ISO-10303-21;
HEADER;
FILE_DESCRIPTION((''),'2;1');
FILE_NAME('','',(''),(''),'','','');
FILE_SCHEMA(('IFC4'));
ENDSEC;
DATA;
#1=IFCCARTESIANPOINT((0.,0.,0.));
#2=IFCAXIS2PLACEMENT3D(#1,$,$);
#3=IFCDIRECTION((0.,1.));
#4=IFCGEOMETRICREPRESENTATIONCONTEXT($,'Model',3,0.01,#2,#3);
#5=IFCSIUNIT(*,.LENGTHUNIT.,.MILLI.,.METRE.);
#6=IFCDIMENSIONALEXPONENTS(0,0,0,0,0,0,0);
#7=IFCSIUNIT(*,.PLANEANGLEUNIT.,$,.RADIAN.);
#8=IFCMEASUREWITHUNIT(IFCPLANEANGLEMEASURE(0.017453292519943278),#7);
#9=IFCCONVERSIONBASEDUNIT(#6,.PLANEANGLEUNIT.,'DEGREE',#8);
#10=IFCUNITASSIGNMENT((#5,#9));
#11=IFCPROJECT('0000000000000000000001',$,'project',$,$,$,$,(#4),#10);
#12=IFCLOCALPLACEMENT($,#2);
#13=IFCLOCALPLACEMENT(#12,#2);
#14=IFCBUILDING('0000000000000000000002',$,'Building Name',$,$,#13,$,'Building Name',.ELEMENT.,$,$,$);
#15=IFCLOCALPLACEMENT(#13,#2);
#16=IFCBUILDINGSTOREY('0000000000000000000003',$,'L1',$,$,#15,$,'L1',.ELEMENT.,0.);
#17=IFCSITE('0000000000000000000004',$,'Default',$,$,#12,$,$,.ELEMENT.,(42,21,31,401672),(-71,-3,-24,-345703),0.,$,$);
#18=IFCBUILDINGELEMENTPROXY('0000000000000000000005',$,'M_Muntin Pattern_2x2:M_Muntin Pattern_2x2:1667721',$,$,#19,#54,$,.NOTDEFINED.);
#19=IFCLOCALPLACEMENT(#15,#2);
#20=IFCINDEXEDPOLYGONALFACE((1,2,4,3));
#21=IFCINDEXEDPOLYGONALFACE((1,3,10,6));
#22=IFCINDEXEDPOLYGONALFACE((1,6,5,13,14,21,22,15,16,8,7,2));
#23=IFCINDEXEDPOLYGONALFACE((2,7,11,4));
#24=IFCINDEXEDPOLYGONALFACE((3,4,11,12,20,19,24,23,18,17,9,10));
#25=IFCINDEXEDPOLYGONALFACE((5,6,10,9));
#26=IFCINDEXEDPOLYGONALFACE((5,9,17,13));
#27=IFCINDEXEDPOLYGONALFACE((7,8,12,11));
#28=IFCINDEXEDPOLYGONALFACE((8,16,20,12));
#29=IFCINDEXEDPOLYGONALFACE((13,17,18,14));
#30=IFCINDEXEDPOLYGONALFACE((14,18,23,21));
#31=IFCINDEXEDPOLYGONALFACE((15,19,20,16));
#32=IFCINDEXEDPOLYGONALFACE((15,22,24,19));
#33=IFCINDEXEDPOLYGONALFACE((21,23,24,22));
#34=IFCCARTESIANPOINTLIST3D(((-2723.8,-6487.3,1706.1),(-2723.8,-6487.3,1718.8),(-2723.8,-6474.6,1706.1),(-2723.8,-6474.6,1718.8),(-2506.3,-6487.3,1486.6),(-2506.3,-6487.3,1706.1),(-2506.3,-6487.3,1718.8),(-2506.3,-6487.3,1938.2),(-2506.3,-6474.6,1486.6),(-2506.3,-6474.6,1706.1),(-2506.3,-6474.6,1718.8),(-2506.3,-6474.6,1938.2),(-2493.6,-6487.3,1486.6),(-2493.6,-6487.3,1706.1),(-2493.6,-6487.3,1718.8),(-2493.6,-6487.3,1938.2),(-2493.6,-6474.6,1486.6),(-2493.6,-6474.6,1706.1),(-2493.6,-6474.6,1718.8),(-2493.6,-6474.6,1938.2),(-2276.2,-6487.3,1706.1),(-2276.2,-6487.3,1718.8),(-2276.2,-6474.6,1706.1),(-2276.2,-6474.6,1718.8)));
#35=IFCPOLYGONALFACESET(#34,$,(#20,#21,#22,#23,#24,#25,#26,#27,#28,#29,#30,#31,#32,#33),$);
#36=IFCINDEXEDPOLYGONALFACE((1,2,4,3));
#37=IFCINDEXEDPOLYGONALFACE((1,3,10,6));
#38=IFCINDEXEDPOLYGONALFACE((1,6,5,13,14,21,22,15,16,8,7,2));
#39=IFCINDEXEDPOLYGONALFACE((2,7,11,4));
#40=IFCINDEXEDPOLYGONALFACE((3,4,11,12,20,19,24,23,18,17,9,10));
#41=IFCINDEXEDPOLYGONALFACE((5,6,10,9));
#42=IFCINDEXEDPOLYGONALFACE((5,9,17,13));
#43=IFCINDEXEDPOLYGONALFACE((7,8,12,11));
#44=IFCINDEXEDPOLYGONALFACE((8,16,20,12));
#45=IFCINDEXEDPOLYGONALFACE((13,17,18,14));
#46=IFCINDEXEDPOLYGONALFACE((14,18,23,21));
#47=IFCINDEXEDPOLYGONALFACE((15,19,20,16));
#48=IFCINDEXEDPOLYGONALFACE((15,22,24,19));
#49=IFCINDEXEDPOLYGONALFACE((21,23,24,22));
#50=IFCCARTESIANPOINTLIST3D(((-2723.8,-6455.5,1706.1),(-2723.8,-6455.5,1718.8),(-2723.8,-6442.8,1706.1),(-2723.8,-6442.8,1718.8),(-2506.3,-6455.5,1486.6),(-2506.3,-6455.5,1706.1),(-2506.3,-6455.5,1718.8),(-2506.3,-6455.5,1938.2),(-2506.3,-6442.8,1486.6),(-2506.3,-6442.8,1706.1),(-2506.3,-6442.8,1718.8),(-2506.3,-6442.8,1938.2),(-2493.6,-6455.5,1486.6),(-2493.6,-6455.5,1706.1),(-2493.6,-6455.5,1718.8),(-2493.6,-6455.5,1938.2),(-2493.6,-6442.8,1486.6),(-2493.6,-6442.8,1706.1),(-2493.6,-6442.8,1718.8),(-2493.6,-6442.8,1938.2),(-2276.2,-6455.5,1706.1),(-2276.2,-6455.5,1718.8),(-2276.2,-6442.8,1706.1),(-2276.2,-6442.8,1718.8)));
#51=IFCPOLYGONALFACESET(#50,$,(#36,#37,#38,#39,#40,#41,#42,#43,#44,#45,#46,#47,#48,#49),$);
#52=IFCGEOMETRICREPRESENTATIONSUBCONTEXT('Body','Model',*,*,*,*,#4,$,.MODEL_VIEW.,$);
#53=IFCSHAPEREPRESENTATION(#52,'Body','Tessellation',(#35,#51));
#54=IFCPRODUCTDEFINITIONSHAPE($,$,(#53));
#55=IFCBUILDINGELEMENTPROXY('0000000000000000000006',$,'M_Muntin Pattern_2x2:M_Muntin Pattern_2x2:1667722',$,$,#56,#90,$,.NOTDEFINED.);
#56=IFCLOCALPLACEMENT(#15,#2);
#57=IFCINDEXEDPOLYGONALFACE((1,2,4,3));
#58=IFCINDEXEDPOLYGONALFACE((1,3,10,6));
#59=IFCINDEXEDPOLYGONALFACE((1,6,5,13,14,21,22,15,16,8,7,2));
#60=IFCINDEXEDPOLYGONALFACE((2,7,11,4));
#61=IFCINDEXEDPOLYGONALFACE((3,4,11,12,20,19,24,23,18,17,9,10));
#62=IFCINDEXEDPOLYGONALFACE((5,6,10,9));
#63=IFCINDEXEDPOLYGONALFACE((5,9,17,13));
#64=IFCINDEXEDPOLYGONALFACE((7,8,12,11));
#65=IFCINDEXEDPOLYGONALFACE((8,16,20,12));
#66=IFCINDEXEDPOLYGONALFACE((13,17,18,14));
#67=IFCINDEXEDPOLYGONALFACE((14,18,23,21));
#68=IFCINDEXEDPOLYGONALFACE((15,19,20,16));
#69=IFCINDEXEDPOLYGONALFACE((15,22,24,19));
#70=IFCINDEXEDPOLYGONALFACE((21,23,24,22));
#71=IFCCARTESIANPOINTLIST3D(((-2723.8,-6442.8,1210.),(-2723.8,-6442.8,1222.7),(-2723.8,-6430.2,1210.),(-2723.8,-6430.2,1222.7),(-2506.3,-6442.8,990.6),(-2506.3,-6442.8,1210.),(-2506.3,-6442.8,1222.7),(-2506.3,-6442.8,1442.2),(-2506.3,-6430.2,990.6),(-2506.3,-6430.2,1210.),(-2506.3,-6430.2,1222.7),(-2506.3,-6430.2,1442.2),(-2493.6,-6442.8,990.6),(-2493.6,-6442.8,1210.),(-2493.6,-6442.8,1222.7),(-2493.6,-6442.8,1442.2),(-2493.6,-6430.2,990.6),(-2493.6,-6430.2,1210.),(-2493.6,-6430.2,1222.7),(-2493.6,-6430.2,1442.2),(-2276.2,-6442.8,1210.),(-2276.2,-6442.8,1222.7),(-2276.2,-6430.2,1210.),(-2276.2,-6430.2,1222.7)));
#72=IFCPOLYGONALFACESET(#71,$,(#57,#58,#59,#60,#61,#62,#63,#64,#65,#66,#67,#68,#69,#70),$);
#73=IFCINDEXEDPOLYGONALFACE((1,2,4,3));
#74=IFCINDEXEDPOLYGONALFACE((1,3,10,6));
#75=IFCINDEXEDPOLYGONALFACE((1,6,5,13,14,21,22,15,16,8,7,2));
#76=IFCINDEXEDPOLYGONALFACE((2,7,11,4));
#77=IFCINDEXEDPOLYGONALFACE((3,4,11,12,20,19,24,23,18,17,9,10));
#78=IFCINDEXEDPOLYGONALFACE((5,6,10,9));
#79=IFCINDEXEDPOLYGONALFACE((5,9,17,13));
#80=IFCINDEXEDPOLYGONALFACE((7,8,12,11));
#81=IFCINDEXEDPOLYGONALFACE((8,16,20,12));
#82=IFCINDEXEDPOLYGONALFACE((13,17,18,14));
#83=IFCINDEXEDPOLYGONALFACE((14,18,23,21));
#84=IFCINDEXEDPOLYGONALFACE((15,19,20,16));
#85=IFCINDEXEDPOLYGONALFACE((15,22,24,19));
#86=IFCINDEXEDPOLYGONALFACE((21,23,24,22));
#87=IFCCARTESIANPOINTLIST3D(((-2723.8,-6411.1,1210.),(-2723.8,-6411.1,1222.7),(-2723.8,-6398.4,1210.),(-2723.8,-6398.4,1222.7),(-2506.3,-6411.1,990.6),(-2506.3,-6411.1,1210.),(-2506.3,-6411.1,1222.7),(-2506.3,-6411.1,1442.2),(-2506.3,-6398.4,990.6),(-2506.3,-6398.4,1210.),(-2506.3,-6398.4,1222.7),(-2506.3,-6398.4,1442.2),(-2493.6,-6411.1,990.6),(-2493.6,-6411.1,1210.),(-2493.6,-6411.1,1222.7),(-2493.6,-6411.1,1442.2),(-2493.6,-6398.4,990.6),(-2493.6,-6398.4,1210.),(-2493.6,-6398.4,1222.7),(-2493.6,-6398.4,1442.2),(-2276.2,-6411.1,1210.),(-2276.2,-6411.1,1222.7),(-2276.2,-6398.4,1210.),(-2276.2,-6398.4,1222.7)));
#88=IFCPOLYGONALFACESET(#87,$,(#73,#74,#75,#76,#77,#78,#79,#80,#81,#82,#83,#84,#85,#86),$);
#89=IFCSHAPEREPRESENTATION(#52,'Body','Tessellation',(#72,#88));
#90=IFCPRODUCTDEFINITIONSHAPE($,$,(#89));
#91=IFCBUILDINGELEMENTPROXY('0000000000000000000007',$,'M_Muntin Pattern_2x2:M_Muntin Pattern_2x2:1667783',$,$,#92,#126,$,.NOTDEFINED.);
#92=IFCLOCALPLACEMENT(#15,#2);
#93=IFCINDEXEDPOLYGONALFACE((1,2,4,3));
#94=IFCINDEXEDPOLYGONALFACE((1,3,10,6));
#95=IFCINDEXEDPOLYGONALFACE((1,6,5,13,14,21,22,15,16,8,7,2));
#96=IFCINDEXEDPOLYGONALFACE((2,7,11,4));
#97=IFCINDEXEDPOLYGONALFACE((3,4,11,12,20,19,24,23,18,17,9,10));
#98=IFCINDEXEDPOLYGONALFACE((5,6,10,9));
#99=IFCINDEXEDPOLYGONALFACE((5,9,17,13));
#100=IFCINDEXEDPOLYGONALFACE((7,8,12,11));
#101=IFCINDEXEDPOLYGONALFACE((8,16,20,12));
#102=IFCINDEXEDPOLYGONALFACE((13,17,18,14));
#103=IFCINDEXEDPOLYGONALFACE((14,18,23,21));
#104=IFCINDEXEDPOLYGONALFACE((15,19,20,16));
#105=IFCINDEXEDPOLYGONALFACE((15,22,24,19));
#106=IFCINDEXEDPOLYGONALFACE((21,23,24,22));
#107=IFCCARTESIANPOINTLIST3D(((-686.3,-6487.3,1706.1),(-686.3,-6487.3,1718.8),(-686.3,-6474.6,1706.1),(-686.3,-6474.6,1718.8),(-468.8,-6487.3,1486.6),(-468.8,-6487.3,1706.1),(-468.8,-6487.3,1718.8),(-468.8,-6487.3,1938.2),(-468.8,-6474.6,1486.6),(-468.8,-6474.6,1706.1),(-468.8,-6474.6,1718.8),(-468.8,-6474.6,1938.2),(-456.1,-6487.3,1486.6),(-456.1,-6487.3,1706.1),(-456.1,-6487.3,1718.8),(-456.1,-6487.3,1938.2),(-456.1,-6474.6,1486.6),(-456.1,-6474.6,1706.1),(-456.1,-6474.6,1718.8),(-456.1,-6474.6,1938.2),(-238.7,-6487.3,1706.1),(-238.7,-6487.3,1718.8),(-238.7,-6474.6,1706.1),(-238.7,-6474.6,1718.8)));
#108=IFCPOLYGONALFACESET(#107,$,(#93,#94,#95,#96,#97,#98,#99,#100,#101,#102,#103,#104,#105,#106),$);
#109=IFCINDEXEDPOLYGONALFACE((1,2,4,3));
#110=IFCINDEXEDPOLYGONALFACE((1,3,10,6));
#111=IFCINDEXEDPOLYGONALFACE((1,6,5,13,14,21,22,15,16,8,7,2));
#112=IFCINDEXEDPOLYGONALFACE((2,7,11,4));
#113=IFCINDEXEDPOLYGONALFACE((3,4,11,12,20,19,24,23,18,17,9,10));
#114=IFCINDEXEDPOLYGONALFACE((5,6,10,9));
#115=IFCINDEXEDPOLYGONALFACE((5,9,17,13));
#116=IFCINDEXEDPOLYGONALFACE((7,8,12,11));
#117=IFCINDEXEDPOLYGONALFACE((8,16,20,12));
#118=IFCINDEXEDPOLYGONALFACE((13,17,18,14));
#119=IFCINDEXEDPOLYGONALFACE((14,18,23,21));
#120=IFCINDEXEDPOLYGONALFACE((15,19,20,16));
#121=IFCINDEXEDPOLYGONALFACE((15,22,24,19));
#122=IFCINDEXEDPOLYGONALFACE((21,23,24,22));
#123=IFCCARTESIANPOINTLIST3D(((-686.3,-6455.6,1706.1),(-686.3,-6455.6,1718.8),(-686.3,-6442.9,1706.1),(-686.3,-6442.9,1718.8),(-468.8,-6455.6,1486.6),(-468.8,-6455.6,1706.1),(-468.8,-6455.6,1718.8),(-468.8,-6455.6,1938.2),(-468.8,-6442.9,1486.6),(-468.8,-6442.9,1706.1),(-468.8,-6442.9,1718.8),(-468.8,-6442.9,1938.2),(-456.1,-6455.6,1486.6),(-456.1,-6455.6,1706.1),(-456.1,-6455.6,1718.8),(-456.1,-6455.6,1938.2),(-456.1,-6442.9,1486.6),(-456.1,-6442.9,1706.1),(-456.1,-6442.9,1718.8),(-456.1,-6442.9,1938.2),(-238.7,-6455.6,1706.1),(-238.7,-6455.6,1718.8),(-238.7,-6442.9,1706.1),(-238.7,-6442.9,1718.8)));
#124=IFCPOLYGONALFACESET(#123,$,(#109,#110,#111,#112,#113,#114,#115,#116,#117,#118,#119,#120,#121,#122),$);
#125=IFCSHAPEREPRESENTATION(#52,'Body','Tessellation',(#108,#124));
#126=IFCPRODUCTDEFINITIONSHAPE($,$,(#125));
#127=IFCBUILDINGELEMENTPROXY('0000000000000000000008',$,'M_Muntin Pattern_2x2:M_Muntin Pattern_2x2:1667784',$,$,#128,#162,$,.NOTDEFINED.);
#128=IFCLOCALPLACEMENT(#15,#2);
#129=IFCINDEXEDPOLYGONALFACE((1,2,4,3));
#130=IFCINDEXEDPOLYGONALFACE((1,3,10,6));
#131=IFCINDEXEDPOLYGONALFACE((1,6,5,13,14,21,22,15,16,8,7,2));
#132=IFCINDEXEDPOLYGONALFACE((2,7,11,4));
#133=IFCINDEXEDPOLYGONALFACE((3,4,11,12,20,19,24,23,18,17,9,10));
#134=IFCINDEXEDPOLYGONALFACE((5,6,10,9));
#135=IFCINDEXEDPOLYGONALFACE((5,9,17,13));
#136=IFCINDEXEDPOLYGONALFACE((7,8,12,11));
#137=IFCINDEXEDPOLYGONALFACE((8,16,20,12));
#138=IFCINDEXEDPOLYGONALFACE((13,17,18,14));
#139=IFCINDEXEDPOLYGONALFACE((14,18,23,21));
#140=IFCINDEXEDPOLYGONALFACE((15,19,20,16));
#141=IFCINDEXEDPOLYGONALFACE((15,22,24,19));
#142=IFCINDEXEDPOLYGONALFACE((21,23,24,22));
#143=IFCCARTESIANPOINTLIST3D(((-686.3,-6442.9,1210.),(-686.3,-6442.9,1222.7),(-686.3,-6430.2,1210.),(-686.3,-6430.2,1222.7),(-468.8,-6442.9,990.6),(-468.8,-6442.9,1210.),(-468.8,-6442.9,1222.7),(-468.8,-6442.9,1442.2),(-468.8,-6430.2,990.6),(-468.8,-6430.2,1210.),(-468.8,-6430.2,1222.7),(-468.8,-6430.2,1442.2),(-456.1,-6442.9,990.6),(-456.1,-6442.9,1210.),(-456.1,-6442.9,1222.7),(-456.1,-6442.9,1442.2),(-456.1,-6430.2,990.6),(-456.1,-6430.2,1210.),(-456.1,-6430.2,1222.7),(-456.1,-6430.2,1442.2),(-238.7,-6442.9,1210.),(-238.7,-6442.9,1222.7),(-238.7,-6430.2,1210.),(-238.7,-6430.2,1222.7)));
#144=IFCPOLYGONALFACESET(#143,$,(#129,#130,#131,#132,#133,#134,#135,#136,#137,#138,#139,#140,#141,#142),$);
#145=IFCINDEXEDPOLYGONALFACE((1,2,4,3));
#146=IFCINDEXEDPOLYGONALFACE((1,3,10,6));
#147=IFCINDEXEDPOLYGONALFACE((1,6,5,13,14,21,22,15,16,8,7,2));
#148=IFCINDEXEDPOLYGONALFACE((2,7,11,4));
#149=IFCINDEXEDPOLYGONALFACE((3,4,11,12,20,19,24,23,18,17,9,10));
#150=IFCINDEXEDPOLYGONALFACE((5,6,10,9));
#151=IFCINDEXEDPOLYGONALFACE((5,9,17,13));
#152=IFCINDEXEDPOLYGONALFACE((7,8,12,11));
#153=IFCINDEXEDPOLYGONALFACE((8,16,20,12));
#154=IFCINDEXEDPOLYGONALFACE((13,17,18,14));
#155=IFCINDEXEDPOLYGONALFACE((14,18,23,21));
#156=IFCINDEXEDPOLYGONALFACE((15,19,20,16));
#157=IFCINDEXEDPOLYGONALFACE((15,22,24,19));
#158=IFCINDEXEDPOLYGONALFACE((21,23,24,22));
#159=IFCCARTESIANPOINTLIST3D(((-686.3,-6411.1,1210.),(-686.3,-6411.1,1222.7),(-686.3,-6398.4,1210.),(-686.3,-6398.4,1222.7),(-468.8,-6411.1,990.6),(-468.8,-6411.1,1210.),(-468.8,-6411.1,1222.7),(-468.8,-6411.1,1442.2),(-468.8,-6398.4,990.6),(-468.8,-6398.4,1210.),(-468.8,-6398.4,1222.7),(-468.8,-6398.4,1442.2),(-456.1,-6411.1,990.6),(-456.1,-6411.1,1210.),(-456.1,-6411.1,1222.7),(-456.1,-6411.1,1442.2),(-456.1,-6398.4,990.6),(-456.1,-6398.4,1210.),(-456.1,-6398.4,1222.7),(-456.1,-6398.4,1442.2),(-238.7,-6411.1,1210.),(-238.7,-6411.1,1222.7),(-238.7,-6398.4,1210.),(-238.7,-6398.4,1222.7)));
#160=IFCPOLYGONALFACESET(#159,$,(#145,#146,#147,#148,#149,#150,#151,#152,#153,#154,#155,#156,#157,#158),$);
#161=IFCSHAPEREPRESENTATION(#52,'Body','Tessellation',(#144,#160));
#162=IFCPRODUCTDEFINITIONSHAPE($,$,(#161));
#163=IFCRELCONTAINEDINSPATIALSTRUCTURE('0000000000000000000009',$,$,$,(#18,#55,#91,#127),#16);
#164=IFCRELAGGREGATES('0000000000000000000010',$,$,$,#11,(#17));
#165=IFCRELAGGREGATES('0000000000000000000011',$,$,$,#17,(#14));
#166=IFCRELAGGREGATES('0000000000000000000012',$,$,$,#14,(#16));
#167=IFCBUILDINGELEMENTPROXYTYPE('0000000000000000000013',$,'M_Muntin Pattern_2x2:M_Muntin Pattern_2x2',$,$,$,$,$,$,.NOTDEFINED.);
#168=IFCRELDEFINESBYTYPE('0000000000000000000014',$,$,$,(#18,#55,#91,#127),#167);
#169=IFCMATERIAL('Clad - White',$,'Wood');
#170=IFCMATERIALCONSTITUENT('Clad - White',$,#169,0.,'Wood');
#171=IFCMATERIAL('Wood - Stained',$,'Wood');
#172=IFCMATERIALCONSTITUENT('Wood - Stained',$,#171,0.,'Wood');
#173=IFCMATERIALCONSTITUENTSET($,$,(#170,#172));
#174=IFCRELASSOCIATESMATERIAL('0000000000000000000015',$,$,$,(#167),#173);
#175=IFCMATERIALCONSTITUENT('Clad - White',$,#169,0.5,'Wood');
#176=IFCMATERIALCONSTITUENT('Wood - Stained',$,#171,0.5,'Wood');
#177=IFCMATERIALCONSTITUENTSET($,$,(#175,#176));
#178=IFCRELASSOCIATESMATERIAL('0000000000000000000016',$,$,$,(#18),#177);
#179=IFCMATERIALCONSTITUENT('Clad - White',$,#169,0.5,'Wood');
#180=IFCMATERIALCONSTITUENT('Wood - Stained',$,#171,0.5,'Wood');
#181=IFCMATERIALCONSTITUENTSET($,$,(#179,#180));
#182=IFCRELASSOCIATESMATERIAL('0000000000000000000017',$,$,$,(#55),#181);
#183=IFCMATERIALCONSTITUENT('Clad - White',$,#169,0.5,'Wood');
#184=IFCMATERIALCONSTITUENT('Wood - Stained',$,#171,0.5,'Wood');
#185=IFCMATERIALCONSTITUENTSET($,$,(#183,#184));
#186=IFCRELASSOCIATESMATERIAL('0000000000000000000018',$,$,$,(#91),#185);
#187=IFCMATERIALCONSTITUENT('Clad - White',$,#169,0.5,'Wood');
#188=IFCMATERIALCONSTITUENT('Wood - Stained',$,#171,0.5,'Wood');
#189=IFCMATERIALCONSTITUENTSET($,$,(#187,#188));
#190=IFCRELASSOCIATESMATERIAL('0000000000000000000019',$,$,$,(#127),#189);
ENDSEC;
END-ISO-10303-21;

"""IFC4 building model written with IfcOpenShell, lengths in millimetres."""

from ifc_helpers import new_model, entity, si_unit, converted_unit, direction, frame, origin, place, context, subcontext, project, spatial, indexed_curve, outline, extrude, source, transform, mapped, material, constituent, constituent_set, type_object, type_shapes, element, save


model = new_model("IFC4")

# Units and contexts
model_context = context("Model", 3, precision=0.01, world=origin(), true_north=direction((0.0, 1.0)))
body_context = subcontext(model_context, "Body", "Model", "MODEL_VIEW")
ifc_project = project(units=[si_unit("LENGTHUNIT", "METRE", prefix="MILLI"), converted_unit("PLANEANGLEUNIT", "DEGREE", entity("IfcPlaneAngleMeasure", 0.017453292519943278), si_unit("PLANEANGLEUNIT", "RADIAN"), dimensions=[0, 0, 0, 0, 0, 0, 0])], contexts=[model_context])

# Site, building, storey
site_placement = place(None, origin())
site = spatial("IfcSite", under=ifc_project, at=site_placement, Name="Default", CompositionType="ELEMENT", RefLatitude=(42, 21, 31, 401672), RefLongitude=(-71, -3, -24, -345703), RefElevation=0.0)
building_placement = place(site_placement, origin())
building = spatial("IfcBuilding", under=site, at=building_placement, Name="Building Name", LongName="Building Name", CompositionType="ELEMENT")
storey_placement = place(building_placement, origin())
storey = spatial("IfcBuildingStorey", under=building, at=storey_placement, Name="L1", LongName="L1", CompositionType="ELEMENT", Elevation=0.0)

# Building element proxies
ifc_material_1 = material(Name="Clad - White", Category="Wood")
ifc_material_2 = material(Name="Wood - Stained", Category="Wood")
ifc_constituent_1 = constituent(ifc_material_1, Name="Clad - White", Category="Wood", fraction=0.0)
ifc_constituent_2 = constituent(ifc_material_2, Name="Wood - Stained", Category="Wood", fraction=0.0)
ifc_constituent_set_1 = constituent_set(constituents=[ifc_constituent_1, ifc_constituent_2])
building_element_proxy_type_1 = type_object("IfcBuildingElementProxyType", Name="M_Muntin Pattern_2x2:M_Muntin Pattern_2x2", PredefinedType="NOTDEFINED", material=ifc_constituent_set_1)
shared_shape_1 = source(origin(), body_context, "Body", "SweptSolid", [
    extrude(outline(indexed_curve([(6.4, -6.4), (225.8, -6.4), (225.8, 6.3), (6.4, 6.3), (6.4, 223.8), (-6.3, 223.8), (-6.3, 6.3), (-225.8, 6.3), (-225.8, -6.4), (-6.3, -6.4), (-6.3, -223.8), (6.4, -223.8), (6.4, -6.4)], self_intersect=False)), frame((0.0, 9.5, 225.8), z_axis=(0.0, 1.0, 0.0), x_axis=(0.0, 0.0, 1.0)), (0.0, 0.0, 1.0), 12.7),
    extrude(outline(indexed_curve([(6.4, -6.4), (225.8, -6.4), (225.8, 6.3), (6.4, 6.3), (6.4, 223.8), (-6.3, 223.8), (-6.3, 6.3), (-225.8, 6.3), (-225.8, -6.4), (-6.3, -6.4), (-6.3, -223.8), (6.4, -223.8), (6.4, -6.4)], self_intersect=False)), frame((0.0, -22.2, 225.8), z_axis=(0.0, 1.0, 0.0), x_axis=(0.0, 0.0, 1.0)), (0.0, 0.0, 1.0), 12.7),
])
type_shapes(building_element_proxy_type_1, [shared_shape_1])
ifc_constituent_3 = constituent(ifc_material_1, Name="Clad - White", Category="Wood", fraction=0.5)
ifc_constituent_4 = constituent(ifc_material_2, Name="Wood - Stained", Category="Wood", fraction=0.5)
ifc_constituent_set_2 = constituent_set(constituents=[ifc_constituent_3, ifc_constituent_4])
proxy_1_placement = place(storey_placement, frame((-2500.0, -6465.1, 1486.6), z_axis=(0.0, 0.0, 1.0), x_axis=(-1.0, 0.0, 0.0)))
element("IfcBuildingElementProxy", 1, at=proxy_1_placement, inside=storey, type_object=building_element_proxy_type_1, material=ifc_constituent_set_2, Name="M_Muntin Pattern_2x2:M_Muntin Pattern_2x2:1667721", PredefinedType="NOTDEFINED", context=body_context, shape_type="MappedRepresentation", body=[
    mapped(shared_shape_1, transform((0.0, 0.0, 0.0), scale=1.0)),
])
ifc_constituent_5 = constituent(ifc_material_1, Name="Clad - White", Category="Wood", fraction=0.5)
ifc_constituent_6 = constituent(ifc_material_2, Name="Wood - Stained", Category="Wood", fraction=0.5)
ifc_constituent_set_3 = constituent_set(constituents=[ifc_constituent_5, ifc_constituent_6])
proxy_2_placement = place(storey_placement, frame((-2500.0, -6420.6, 990.6), z_axis=(0.0, 0.0, 1.0), x_axis=(-1.0, 0.0, 0.0)))
element("IfcBuildingElementProxy", 2, at=proxy_2_placement, inside=storey, type_object=building_element_proxy_type_1, material=ifc_constituent_set_3, Name="M_Muntin Pattern_2x2:M_Muntin Pattern_2x2:1667722", PredefinedType="NOTDEFINED", context=body_context, shape_type="MappedRepresentation", body=[
    mapped(shared_shape_1, transform((0.0, 0.0, 0.0), scale=1.0)),
])
ifc_constituent_7 = constituent(ifc_material_1, Name="Clad - White", Category="Wood", fraction=0.5)
ifc_constituent_8 = constituent(ifc_material_2, Name="Wood - Stained", Category="Wood", fraction=0.5)
ifc_constituent_set_4 = constituent_set(constituents=[ifc_constituent_7, ifc_constituent_8])
proxy_3_placement = place(storey_placement, frame((-462.5, -6465.1, 1486.6), z_axis=(0.0, 0.0, 1.0), x_axis=(-1.0, 0.0, 0.0)))
element("IfcBuildingElementProxy", 3, at=proxy_3_placement, inside=storey, type_object=building_element_proxy_type_1, material=ifc_constituent_set_4, Name="M_Muntin Pattern_2x2:M_Muntin Pattern_2x2:1667783", PredefinedType="NOTDEFINED", context=body_context, shape_type="MappedRepresentation", body=[
    mapped(shared_shape_1, transform((0.0, 0.0, 0.0), scale=1.0)),
])
ifc_constituent_9 = constituent(ifc_material_1, Name="Clad - White", Category="Wood", fraction=0.5)
ifc_constituent_10 = constituent(ifc_material_2, Name="Wood - Stained", Category="Wood", fraction=0.5)
ifc_constituent_set_5 = constituent_set(constituents=[ifc_constituent_9, ifc_constituent_10])
proxy_4_placement = place(storey_placement, frame((-462.5, -6420.6, 990.6), z_axis=(0.0, 0.0, 1.0), x_axis=(-1.0, 0.0, 0.0)))
element("IfcBuildingElementProxy", 4, at=proxy_4_placement, inside=storey, type_object=building_element_proxy_type_1, material=ifc_constituent_set_5, Name="M_Muntin Pattern_2x2:M_Muntin Pattern_2x2:1667784", PredefinedType="NOTDEFINED", context=body_context, shape_type="MappedRepresentation", body=[
    mapped(shared_shape_1, transform((0.0, 0.0, 0.0), scale=1.0)),
])

save(model, "model.ifc")
